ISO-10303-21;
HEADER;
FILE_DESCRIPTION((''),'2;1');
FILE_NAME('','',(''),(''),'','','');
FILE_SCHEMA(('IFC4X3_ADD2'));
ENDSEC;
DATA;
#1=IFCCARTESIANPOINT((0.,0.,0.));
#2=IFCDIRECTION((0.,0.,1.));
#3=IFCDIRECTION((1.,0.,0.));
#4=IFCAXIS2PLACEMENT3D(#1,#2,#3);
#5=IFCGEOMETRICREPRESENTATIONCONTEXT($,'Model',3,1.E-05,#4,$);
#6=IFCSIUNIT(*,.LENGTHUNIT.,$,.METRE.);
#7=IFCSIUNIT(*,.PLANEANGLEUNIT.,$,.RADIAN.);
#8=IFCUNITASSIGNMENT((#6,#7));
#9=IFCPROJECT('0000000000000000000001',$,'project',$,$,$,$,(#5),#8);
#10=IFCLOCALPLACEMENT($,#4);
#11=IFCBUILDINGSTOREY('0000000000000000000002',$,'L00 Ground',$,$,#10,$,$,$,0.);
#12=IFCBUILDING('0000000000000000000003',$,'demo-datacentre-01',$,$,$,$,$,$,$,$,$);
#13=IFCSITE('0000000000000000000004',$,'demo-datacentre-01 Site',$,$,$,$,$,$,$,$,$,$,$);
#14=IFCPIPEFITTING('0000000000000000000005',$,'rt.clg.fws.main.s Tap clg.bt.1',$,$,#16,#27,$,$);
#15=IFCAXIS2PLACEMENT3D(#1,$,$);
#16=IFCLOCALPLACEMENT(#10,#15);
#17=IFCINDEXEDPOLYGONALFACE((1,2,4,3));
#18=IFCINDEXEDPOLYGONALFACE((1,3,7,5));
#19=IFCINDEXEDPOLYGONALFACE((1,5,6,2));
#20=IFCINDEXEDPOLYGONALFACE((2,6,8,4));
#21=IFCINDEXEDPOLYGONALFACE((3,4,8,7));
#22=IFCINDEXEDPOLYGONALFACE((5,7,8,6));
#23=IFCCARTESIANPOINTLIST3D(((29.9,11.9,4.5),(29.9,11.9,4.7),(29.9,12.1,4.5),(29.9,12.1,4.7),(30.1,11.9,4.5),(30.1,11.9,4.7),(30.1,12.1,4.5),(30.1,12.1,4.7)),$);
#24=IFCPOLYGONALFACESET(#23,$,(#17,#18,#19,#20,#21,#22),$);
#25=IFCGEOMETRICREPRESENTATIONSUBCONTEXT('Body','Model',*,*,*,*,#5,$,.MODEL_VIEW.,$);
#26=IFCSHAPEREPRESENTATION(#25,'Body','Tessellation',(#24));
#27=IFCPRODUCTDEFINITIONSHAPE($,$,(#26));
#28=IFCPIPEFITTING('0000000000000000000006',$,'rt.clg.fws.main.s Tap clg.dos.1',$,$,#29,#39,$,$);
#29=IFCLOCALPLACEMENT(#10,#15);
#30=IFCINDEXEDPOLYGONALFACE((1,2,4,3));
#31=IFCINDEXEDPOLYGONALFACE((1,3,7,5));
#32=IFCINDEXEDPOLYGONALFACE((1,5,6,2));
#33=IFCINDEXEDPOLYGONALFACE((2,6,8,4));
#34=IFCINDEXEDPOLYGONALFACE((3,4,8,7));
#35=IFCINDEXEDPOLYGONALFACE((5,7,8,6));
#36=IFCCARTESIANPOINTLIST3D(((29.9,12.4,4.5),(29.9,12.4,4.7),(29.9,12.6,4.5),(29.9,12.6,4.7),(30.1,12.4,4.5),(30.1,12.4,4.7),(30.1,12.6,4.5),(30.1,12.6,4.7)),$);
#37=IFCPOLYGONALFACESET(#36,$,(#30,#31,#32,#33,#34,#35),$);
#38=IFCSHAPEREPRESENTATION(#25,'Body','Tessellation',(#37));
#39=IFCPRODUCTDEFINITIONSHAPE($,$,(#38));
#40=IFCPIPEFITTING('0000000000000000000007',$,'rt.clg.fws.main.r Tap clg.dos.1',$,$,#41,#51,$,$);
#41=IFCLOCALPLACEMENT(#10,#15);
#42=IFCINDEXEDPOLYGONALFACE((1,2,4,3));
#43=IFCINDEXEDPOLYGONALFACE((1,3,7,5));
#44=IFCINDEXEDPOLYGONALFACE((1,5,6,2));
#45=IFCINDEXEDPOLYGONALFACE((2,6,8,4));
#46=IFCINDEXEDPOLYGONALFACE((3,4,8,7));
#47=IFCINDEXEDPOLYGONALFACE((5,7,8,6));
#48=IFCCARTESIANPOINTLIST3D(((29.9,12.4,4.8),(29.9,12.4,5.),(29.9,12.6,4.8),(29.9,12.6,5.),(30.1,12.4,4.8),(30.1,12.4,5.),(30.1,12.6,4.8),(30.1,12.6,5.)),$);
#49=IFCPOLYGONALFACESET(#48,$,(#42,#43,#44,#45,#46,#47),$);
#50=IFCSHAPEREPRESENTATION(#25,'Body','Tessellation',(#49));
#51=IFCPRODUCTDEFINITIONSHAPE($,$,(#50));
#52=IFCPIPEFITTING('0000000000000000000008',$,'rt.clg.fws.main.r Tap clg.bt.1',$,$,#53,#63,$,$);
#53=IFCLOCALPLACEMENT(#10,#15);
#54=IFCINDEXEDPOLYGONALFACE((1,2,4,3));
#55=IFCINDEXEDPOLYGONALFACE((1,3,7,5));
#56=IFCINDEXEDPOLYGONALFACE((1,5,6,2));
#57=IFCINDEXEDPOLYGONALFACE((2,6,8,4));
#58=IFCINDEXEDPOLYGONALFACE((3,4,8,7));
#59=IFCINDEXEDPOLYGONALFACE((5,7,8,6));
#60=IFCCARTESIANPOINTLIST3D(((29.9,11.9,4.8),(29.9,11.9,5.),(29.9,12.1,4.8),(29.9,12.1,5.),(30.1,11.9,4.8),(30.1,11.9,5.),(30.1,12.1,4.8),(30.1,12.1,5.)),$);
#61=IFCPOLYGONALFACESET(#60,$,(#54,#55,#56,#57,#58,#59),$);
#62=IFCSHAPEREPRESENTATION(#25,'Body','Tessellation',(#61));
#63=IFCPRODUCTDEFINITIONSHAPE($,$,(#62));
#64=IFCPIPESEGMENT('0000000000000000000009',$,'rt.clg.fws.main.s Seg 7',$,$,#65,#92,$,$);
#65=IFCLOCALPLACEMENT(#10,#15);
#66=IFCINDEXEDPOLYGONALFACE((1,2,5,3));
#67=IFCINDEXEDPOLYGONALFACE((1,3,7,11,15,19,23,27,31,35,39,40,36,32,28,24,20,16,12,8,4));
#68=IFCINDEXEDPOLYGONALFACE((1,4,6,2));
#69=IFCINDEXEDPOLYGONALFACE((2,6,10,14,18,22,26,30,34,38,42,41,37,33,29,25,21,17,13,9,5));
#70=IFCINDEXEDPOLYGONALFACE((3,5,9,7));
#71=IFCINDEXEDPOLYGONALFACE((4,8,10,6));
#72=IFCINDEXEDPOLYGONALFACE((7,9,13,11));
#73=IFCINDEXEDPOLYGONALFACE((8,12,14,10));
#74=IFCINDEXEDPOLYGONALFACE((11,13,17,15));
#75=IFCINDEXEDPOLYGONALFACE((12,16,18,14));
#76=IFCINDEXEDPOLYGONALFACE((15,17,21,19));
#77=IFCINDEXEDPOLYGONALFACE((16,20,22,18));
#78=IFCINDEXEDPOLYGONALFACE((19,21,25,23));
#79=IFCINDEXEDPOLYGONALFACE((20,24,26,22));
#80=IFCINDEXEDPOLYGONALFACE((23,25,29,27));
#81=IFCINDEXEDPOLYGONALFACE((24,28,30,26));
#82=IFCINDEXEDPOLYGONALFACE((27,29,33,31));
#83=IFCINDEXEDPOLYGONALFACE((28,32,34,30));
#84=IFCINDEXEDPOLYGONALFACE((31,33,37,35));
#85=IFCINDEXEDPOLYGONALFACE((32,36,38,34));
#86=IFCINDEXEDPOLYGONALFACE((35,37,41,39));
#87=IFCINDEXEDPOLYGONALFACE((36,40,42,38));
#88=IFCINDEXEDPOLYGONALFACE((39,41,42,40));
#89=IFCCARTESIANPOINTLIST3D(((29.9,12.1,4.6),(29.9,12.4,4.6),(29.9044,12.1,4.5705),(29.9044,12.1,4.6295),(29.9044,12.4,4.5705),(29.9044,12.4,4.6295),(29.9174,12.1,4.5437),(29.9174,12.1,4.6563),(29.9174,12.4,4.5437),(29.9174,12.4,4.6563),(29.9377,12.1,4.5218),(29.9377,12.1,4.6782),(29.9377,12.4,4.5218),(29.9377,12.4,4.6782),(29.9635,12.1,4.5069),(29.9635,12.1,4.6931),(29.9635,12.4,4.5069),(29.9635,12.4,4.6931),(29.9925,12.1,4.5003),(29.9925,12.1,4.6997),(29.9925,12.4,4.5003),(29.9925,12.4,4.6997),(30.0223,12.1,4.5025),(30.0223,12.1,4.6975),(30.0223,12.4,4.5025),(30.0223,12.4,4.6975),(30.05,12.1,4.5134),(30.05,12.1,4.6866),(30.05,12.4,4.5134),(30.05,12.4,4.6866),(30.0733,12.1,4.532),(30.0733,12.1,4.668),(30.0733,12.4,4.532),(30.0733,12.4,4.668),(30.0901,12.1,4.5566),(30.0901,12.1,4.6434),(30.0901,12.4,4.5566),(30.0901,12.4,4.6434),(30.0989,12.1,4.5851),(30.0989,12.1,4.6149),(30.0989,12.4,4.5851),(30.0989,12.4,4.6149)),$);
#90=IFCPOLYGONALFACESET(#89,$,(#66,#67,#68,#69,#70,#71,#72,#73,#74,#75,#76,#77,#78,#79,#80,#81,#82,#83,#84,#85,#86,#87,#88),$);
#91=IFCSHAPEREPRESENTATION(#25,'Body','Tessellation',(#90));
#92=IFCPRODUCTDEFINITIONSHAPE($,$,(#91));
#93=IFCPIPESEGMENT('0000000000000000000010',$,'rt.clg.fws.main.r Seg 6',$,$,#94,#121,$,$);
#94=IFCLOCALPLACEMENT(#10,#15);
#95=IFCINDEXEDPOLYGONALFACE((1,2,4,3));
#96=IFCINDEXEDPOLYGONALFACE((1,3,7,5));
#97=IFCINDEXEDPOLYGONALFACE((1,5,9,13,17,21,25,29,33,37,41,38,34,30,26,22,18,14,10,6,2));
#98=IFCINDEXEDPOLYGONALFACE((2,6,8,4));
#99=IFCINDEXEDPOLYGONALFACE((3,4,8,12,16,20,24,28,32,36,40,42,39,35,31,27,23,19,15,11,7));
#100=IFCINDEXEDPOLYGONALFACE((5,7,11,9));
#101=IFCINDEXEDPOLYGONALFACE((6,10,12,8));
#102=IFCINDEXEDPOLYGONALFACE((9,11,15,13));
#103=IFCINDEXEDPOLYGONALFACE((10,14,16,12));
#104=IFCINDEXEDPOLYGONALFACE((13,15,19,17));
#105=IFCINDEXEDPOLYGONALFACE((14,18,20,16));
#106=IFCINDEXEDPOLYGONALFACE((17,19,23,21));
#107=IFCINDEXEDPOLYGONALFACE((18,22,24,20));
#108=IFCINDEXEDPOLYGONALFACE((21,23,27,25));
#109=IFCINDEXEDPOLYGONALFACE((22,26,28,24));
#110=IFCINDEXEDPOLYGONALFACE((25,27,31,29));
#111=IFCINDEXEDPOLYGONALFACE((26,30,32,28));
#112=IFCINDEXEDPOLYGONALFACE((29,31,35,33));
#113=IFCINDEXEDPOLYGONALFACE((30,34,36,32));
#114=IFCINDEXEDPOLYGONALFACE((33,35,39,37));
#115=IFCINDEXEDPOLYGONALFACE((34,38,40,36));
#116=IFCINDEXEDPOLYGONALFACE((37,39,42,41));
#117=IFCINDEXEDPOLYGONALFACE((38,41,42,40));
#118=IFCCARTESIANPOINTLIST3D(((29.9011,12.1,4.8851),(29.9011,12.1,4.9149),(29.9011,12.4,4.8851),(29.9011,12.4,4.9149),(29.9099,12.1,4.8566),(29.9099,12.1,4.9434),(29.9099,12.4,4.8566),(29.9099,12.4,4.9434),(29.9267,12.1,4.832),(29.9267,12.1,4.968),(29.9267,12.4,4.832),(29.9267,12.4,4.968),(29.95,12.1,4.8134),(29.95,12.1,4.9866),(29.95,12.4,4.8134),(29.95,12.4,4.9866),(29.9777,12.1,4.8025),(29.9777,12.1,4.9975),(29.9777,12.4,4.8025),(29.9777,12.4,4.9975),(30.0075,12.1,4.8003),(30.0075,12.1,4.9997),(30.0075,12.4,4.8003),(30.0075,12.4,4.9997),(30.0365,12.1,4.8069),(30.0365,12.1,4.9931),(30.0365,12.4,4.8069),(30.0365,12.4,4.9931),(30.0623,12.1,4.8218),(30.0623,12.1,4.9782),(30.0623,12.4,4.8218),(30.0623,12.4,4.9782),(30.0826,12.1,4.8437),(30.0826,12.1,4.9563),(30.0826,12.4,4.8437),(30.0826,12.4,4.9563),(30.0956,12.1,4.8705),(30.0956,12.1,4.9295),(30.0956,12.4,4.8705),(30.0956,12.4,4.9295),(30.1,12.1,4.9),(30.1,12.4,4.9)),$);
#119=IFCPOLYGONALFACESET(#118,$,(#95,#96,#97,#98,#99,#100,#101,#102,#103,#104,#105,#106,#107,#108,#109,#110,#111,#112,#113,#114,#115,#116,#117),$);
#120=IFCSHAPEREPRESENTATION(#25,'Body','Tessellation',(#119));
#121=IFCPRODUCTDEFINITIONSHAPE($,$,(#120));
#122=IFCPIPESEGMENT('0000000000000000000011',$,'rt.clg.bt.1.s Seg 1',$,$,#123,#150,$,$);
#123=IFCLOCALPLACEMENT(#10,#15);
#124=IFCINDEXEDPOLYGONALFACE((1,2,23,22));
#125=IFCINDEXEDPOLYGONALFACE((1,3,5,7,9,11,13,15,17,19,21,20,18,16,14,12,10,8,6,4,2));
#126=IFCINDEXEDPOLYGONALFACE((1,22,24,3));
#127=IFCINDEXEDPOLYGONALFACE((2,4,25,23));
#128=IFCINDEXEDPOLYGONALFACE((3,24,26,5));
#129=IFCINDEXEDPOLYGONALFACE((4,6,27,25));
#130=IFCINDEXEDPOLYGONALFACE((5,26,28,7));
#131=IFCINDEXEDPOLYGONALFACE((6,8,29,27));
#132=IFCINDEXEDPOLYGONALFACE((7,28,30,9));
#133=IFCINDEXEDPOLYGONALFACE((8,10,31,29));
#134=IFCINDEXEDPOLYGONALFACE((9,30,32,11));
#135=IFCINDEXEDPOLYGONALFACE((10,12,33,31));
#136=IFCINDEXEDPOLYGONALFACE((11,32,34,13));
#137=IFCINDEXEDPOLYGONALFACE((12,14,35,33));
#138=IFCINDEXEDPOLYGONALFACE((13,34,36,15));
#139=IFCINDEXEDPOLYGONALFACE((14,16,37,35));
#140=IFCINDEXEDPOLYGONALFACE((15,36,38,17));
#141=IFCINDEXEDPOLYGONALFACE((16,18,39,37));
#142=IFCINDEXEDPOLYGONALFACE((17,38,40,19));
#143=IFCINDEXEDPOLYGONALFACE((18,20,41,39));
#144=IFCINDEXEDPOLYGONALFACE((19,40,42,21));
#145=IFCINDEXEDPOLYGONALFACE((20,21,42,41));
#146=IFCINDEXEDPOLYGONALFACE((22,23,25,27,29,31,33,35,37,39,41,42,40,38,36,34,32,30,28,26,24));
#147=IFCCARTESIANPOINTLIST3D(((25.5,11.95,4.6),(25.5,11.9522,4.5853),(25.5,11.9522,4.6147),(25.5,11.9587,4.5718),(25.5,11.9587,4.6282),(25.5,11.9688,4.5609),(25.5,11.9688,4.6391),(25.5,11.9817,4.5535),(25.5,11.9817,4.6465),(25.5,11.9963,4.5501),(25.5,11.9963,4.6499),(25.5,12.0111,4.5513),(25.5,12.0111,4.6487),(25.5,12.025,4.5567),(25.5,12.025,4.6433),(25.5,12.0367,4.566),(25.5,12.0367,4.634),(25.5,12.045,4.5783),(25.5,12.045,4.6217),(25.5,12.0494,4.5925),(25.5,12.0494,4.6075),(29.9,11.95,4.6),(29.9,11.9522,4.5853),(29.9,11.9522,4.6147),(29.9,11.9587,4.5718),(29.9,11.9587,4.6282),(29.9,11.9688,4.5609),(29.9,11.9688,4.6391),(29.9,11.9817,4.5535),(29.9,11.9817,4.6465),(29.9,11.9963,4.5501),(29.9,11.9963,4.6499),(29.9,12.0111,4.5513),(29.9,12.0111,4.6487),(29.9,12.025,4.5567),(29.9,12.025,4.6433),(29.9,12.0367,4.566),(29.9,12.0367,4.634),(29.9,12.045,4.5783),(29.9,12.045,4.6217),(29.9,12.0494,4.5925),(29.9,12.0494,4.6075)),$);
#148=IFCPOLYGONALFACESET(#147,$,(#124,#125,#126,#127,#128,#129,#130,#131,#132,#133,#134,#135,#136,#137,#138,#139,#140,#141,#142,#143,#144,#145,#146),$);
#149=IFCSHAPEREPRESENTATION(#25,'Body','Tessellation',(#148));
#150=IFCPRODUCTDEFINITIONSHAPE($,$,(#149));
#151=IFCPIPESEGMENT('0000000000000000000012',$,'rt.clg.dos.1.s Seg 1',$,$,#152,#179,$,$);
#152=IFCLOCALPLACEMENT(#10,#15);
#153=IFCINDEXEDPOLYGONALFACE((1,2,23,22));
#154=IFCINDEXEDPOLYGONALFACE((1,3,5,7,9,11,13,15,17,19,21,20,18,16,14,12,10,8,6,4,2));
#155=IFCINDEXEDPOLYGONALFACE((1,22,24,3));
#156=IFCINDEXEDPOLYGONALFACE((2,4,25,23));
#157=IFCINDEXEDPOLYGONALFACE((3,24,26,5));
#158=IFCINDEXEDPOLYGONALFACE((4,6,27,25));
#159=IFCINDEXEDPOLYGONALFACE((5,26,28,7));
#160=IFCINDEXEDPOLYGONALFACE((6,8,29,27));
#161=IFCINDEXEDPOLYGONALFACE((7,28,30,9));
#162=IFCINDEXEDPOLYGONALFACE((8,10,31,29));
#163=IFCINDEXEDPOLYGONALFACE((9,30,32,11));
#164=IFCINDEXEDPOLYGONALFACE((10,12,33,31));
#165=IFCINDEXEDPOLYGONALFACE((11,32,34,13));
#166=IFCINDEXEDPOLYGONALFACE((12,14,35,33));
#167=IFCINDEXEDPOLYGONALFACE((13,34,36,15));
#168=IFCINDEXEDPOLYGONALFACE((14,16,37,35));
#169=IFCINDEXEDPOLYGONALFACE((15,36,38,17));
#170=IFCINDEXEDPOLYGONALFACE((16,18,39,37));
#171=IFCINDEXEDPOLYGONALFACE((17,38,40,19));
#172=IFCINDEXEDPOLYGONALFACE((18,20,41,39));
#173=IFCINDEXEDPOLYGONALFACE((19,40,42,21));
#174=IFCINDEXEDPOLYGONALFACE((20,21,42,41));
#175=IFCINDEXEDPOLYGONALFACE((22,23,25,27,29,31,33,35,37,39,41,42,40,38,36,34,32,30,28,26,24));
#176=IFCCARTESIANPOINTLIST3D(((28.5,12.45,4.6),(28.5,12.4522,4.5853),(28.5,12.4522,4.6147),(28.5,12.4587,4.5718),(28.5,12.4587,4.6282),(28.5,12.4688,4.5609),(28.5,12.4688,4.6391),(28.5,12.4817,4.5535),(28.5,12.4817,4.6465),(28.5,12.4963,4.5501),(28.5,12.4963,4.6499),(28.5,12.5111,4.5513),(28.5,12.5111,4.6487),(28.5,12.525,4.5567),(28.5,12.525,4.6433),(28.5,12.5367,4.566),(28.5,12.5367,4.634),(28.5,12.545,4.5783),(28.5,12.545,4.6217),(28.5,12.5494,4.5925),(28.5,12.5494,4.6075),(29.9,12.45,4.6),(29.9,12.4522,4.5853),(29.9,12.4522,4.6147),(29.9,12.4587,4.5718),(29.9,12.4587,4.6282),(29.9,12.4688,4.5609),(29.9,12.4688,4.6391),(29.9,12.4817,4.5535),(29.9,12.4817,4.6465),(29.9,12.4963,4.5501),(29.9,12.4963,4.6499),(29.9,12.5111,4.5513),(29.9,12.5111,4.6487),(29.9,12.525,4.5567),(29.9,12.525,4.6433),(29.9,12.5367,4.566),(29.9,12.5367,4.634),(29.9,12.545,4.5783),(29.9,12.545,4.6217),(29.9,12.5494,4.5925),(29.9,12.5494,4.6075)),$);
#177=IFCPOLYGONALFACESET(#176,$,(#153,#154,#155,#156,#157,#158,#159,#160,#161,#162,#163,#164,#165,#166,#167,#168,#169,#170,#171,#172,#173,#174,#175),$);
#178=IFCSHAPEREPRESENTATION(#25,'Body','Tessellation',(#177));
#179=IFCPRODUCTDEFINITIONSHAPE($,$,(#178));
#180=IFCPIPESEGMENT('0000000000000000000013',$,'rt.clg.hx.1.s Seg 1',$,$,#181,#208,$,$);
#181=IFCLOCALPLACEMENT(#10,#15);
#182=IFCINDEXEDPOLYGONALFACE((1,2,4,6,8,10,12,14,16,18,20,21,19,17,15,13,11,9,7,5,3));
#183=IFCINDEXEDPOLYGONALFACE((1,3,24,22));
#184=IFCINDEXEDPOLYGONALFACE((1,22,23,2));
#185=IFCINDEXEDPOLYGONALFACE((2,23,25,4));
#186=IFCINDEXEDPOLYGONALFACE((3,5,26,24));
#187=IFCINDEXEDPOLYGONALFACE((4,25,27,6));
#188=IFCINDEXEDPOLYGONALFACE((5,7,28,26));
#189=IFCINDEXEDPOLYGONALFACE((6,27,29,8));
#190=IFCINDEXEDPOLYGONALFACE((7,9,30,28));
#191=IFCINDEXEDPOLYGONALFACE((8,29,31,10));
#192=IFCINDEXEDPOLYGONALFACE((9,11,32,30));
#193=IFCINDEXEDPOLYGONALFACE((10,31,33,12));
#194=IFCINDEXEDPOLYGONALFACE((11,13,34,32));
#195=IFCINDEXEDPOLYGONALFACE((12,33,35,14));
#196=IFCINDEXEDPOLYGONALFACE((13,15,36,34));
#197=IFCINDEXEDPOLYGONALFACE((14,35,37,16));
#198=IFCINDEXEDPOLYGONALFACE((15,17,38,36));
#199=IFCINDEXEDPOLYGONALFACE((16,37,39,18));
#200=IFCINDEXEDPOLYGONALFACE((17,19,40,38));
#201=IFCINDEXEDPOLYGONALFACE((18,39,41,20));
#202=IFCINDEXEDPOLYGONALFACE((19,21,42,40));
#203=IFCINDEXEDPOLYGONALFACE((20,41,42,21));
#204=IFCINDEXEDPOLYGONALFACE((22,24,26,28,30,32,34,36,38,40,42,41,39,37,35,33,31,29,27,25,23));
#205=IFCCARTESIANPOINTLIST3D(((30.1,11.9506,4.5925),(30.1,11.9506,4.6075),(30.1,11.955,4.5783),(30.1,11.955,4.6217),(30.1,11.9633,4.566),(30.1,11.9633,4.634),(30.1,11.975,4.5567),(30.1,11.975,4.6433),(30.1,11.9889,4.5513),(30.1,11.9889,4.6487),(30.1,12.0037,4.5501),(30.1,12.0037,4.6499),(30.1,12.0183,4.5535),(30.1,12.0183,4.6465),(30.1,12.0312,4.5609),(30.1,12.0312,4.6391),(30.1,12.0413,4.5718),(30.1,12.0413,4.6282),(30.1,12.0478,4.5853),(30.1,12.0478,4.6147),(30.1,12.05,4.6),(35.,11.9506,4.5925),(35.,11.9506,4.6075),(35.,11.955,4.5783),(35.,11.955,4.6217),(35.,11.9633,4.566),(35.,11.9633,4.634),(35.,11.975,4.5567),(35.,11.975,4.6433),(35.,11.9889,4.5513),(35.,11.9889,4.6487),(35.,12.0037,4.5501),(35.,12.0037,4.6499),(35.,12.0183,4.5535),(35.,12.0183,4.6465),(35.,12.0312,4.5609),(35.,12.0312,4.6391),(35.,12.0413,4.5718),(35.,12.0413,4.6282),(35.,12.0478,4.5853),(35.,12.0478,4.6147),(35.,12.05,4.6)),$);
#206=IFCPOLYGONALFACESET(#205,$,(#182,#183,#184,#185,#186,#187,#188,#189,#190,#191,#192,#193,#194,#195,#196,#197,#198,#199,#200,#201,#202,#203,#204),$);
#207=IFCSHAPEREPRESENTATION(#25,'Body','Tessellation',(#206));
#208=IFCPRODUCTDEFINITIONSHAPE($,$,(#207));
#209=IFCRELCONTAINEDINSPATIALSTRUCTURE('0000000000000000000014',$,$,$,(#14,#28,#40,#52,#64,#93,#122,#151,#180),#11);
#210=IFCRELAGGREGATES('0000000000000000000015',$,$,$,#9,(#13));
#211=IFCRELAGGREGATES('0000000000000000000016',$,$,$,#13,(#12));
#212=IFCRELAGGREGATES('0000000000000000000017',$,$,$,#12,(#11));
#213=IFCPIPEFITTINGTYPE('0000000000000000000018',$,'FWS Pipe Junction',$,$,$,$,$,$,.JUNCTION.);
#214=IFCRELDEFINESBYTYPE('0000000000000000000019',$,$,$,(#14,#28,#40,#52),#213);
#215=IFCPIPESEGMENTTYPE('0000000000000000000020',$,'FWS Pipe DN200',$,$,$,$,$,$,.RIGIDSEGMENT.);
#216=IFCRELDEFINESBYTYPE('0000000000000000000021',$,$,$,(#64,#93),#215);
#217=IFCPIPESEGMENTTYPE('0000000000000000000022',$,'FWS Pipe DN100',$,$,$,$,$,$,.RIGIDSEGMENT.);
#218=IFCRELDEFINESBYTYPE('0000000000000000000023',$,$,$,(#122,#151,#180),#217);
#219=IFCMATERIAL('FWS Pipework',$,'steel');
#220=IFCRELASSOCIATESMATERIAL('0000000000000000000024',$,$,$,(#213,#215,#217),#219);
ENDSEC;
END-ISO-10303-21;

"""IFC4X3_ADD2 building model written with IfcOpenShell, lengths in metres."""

from ifc_helpers import new_model, si_unit, frame, origin_with_axes, place, context, subcontext, project, spatial, rectangle, circle, extrude, material, type_object, element, save


model = new_model("IFC4X3_ADD2")

# Units and contexts
model_context = context("Model", 3, precision=1e-05, world=origin_with_axes())
body_context = subcontext(model_context, "Body", "Model", "MODEL_VIEW")
ifc_project = project(units=[si_unit("LENGTHUNIT", "METRE"), si_unit("PLANEANGLEUNIT", "RADIAN")], contexts=[model_context])

# Site, building, storey
site = spatial("IfcSite", under=ifc_project, Name="demo-datacentre-01 Site")
building = spatial("IfcBuilding", under=site, Name="demo-datacentre-01")
storey_placement = place(None, origin_with_axes())
storey = spatial("IfcBuildingStorey", under=building, at=storey_placement, Name="L00 Ground", Elevation=0.0)

# Pipe fittings
ifc_material_1 = material(Name="FWS Pipework", Category="steel")
pipe_fitting_type_1 = type_object("IfcPipeFittingType", Name="FWS Pipe Junction", PredefinedType="JUNCTION", material=ifc_material_1)
for number, where, z_axis, x_axis, name in (
    (1, (30.0, 12.0, 4.5), (0.0, 0.0, 1.0), (1.0, 0.0, 0.0), "rt.clg.fws.main.s Tap clg.bt.1"),
    (2, (30.0, 12.5, 4.5), (0.0, 0.0, 1.0), (1.0, 0.0, 0.0), "rt.clg.fws.main.s Tap clg.dos.1"),
    (3, (30.0, 12.5, 4.8), (0.0, 0.0, 1.0), (1.0, 0.0, 0.0), "rt.clg.fws.main.r Tap clg.dos.1"),
    (4, (30.0, 12.0, 4.8), (0.0, 0.0, 1.0), (1.0, 0.0, 0.0), "rt.clg.fws.main.r Tap clg.bt.1"),
):
    element("IfcPipeFitting", number, at=place(storey_placement, frame(where, z_axis=z_axis, x_axis=x_axis)), inside=storey, type_object=pipe_fitting_type_1, Name=name, context=body_context, shape_type="SweptSolid", body=[
        extrude(rectangle(XDim=0.2, YDim=0.2), origin_with_axes(), (0.0, 0.0, 1.0), 0.2),
    ])

# Pipe segments
pipe_segment_type_1 = type_object("IfcPipeSegmentType", Name="FWS Pipe DN200", PredefinedType="RIGIDSEGMENT", material=ifc_material_1)
for number, where, z_axis, x_axis, name in (
    (5, (30.0, 12.1, 4.6), (0.0, 1.0, 0.0), (-1.0, 0.0, 0.0), "rt.clg.fws.main.s Seg 7"),
    (6, (30.0, 12.4, 4.9), (0.0, -1.0, 0.0), (1.0, 0.0, 0.0), "rt.clg.fws.main.r Seg 6"),
):
    element("IfcPipeSegment", number, at=place(storey_placement, frame(where, z_axis=z_axis, x_axis=x_axis)), inside=storey, type_object=pipe_segment_type_1, Name=name, context=body_context, shape_type="SweptSolid", body=[
        extrude(circle(Radius=0.1), origin_with_axes(), (0.0, 0.0, 1.0), 0.3),
    ])
pipe_segment_type_2 = type_object("IfcPipeSegmentType", Name="FWS Pipe DN100", PredefinedType="RIGIDSEGMENT", material=ifc_material_1)
pipe_segment_1_placement = place(storey_placement, frame((29.9, 12.0, 4.6), z_axis=(-1.0, 0.0, 0.0), x_axis=(0.0, -1.0, 0.0)))
element("IfcPipeSegment", 7, at=pipe_segment_1_placement, inside=storey, type_object=pipe_segment_type_2, Name="rt.clg.bt.1.s Seg 1", context=body_context, shape_type="SweptSolid", body=[
    extrude(circle(Radius=0.05), origin_with_axes(), (0.0, 0.0, 1.0), 4.4),
])
pipe_segment_2_placement = place(storey_placement, frame((29.9, 12.5, 4.6), z_axis=(-1.0, 0.0, 0.0), x_axis=(0.0, -1.0, 0.0)))
element("IfcPipeSegment", 8, at=pipe_segment_2_placement, inside=storey, type_object=pipe_segment_type_2, Name="rt.clg.dos.1.s Seg 1", context=body_context, shape_type="SweptSolid", body=[
    extrude(circle(Radius=0.05), origin_with_axes(), (0.0, 0.0, 1.0), 1.4),
])
for number, where, z_axis, x_axis, name in (
    (9, (30.1, 12.0, 4.6), (1.0, 0.0, 0.0), (0.0, 1.0, 0.0), "rt.clg.hx.1.s Seg 1"),
):
    element("IfcPipeSegment", number, at=place(storey_placement, frame(where, z_axis=z_axis, x_axis=x_axis)), inside=storey, type_object=pipe_segment_type_2, Name=name, context=body_context, shape_type="SweptSolid", body=[
        extrude(circle(Radius=0.05), origin_with_axes(), (0.0, 0.0, 1.0), 4.9),
    ])

save(model, "model.ifc")
